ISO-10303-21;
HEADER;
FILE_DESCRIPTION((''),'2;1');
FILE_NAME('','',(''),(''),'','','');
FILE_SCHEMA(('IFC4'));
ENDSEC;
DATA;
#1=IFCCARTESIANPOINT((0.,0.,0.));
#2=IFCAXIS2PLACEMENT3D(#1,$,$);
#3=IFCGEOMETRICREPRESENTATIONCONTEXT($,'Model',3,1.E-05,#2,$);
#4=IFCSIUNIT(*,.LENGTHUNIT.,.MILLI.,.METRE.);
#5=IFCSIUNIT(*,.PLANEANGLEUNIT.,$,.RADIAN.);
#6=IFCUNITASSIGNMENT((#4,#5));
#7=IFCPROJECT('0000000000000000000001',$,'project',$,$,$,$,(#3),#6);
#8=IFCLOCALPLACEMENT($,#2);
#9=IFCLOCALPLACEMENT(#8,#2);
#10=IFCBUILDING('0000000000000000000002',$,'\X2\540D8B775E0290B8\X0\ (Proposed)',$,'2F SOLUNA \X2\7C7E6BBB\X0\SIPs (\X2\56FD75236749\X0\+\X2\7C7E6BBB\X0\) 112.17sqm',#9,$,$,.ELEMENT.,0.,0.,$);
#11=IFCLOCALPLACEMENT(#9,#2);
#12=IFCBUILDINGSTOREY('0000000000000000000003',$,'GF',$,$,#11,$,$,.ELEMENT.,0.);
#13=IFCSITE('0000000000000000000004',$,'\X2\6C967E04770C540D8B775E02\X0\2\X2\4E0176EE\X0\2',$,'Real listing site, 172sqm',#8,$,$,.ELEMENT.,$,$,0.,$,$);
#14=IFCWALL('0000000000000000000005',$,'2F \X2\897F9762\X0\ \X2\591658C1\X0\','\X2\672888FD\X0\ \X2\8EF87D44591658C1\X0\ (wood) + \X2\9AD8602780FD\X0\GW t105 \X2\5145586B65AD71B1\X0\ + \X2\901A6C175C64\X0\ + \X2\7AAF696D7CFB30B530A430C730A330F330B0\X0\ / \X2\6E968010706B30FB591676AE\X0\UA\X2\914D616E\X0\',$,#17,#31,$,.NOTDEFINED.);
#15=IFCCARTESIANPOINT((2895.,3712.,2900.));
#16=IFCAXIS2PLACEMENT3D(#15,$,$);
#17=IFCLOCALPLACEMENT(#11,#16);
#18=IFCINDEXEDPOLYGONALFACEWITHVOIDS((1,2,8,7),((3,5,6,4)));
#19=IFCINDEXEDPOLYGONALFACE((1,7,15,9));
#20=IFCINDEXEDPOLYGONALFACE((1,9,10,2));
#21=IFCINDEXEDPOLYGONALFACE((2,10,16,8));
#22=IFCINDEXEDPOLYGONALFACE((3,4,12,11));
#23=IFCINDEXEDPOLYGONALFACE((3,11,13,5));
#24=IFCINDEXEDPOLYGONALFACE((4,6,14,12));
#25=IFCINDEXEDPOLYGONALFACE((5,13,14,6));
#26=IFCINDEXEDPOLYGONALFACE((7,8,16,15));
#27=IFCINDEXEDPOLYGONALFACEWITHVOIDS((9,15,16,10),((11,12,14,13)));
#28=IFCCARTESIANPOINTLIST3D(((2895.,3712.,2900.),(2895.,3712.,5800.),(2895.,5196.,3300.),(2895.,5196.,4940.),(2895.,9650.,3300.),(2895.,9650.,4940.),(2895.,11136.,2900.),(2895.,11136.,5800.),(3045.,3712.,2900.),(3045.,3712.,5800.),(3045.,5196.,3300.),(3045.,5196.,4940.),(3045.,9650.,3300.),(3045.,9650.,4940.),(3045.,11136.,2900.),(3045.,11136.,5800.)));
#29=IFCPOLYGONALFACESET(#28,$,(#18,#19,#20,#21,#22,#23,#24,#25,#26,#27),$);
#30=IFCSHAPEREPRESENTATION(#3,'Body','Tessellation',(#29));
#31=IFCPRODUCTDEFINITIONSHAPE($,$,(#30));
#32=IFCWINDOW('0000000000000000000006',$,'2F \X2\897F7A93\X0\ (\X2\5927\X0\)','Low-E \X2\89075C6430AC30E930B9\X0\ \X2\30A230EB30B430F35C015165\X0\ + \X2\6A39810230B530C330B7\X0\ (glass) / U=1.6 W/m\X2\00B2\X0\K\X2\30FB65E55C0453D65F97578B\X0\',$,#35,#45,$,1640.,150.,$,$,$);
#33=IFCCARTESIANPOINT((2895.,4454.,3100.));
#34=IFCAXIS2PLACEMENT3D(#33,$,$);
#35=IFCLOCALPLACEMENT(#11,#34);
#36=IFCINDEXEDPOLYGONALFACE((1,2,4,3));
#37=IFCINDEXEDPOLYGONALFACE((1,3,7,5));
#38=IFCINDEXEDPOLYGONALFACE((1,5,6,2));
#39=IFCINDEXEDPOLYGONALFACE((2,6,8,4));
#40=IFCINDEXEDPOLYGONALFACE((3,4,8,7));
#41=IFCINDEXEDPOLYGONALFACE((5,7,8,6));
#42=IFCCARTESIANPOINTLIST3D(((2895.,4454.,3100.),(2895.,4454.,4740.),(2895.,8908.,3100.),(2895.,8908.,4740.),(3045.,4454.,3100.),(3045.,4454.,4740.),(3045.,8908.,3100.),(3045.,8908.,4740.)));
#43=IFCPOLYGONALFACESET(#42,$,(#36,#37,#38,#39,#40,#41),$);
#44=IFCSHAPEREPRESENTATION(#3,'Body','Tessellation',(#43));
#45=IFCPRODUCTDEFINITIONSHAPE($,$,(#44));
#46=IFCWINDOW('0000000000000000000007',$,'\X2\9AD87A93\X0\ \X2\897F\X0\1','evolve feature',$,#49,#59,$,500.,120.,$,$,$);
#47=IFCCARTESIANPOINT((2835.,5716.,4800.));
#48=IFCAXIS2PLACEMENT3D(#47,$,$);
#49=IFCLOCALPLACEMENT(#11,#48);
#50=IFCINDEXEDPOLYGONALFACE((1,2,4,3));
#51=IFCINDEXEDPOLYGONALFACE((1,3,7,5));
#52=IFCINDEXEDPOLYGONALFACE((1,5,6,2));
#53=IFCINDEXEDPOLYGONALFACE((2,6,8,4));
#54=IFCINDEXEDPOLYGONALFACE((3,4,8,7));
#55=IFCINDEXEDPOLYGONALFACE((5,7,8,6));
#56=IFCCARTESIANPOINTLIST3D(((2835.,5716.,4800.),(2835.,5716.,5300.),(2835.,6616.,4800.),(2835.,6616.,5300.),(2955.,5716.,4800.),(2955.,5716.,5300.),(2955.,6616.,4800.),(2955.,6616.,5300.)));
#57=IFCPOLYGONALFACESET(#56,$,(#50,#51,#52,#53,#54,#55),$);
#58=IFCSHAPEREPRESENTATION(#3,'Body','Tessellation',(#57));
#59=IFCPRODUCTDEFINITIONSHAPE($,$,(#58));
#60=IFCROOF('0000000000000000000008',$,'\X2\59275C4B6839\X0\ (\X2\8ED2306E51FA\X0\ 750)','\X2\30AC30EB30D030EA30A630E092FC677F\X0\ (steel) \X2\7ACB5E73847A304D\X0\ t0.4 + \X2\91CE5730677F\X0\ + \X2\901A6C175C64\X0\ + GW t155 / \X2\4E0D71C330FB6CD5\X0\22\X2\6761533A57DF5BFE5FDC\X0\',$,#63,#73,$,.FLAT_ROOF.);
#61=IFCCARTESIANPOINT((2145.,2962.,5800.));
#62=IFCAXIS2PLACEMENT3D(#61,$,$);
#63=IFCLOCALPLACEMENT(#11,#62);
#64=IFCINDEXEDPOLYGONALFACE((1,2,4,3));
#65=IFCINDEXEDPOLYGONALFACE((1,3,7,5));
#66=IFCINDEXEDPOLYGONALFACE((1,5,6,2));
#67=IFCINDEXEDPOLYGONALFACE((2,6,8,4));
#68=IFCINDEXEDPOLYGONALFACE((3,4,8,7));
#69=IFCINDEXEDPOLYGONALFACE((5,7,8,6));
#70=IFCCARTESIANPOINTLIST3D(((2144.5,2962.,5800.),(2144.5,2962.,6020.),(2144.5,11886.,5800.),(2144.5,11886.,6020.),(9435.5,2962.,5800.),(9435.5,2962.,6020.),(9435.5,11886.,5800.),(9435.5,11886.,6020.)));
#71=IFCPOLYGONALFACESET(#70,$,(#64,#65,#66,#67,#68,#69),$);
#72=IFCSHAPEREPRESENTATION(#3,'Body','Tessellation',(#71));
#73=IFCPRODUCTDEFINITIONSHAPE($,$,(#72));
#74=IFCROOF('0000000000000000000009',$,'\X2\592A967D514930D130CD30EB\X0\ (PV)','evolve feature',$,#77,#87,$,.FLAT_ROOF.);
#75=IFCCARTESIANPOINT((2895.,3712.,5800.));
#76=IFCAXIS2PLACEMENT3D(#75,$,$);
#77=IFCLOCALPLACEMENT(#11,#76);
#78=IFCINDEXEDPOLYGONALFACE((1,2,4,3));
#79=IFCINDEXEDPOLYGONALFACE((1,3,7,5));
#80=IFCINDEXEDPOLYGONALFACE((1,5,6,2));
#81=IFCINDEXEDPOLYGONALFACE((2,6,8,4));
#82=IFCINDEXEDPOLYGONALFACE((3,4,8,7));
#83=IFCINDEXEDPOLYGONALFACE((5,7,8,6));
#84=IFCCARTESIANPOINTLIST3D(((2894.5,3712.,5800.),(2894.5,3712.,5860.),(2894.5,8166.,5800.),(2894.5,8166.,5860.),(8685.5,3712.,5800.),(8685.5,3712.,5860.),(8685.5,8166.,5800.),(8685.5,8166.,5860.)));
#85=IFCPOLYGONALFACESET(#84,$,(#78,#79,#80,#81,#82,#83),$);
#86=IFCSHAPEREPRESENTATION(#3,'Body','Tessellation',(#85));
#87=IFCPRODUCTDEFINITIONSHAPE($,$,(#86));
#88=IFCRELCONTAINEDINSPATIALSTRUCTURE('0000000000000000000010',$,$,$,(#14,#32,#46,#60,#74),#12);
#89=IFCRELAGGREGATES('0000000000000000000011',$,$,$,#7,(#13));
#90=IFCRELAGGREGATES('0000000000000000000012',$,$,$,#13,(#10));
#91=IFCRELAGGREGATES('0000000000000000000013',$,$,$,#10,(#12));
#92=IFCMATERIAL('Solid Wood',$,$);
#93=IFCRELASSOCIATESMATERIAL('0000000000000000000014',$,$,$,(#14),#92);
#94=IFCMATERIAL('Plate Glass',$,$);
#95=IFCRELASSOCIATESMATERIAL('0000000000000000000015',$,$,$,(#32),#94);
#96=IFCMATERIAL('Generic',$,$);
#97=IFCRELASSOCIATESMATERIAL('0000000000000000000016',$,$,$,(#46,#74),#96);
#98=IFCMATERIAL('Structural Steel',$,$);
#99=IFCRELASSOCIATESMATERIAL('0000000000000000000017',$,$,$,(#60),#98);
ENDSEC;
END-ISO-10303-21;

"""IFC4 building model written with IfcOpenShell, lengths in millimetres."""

from ifc_helpers import new_model, si_unit, frame, frame_2d, origin, place, context, project, spatial, rectangle, extrude, material, element, fill, save


model = new_model("IFC4")

# Units and contexts
model_context = context("Model", 3, precision=1e-05, world=origin())
ifc_project = project(units=[si_unit("LENGTHUNIT", "METRE", prefix="MILLI"), si_unit("PLANEANGLEUNIT", "RADIAN")], contexts=[model_context])

# Site, building, storey
site_placement = place(None, origin())
site = spatial("IfcSite", under=ifc_project, at=site_placement, Name="沖縄県名護市2丁目2", ObjectType="Real listing site, 172sqm", CompositionType="ELEMENT", RefElevation=0.0)
building_placement = place(site_placement, origin())
building = spatial("IfcBuilding", under=site, at=building_placement, Name="名護市邸 (Proposed)", ObjectType="2F SOLUNA 籾殻SIPs (国産杉+籾殻) 112.17sqm", CompositionType="ELEMENT", ElevationOfRefHeight=0.0, ElevationOfTerrain=0.0)
storey_placement = place(building_placement, origin())
storey = spatial("IfcBuildingStorey", under=building, at=storey_placement, Name="GF", CompositionType="ELEMENT", Elevation=0.0)

# Shared definitions
ifc_material_1 = material(Name="Solid Wood")
ifc_material_2 = material(Name="Generic")

# Shared definitions
ifc_material_3 = material(Name="Plate Glass")

# Wall, openings, windows
wall_1_placement = place(storey_placement, frame((2895.0, 3712.0, 2900.0)))
wall_1 = element("IfcWall", 1, at=wall_1_placement, inside=storey, material=ifc_material_1, Name="2F 西面 外壁", Description="木製 軸組外壁 (wood) + 高性能GW t105 充填断熱 + 通気層 + 窯業系サイディング / 準耐火・外皮UA配慮", PredefinedType="NOTDEFINED", context=model_context, shape_type="SweptSolid", body=[
    extrude(rectangle(XDim=150.0, YDim=7424.0, at=frame_2d((75.0, 3712.0))), frame((2895.0, 3712.0, 2900.0)), (0.0, 0.0, 1.0), 2900.0),
])
opening_1_placement = place(storey_placement, frame((2895.0, 4454.0, 3100.0)))
opening_1 = element("IfcOpeningElement", 2, at=opening_1_placement, cuts=wall_1, PredefinedType="NOTDEFINED", context=model_context, shape_type="SweptSolid", body=[
    extrude(rectangle(XDim=150.0, YDim=4454.0, at=frame_2d((75.0, 2227.0))), frame((2895.0, 4454.0, 3100.0)), (0.0, 0.0, 1.0), 1640.0),
])
opening_2_placement = place(storey_placement, frame((2835.0, 5716.0, 4800.0)))
opening_2 = element("IfcOpeningElement", 3, at=opening_2_placement, cuts=wall_1, PredefinedType="NOTDEFINED", context=model_context, shape_type="SweptSolid", body=[
    extrude(rectangle(XDim=120.0, YDim=900.0, at=frame_2d((60.0, 450.0))), frame((2835.0, 5716.0, 4800.0)), (0.0, 0.0, 1.0), 500.0),
])
window_1_placement = place(storey_placement, frame((2895.0, 4454.0, 3100.0)))
window_1 = element("IfcWindow", 4, at=window_1_placement, inside=storey, material=ifc_material_3, Name="2F 西窓 (大)", Description="Low-E 複層ガラス アルゴン封入 + 樹脂サッシ (glass) / U=1.6 W/m²K・日射取得型", OverallHeight=1640.0, OverallWidth=150.0, context=model_context, shape_type="SweptSolid", body=[
    extrude(rectangle(XDim=150.0, YDim=4454.0, at=frame_2d((75.0, 2227.0))), frame((2895.0, 4454.0, 3100.0)), (0.0, 0.0, 1.0), 1640.0),
])
fill(opening_1, window_1)
window_2_placement = place(storey_placement, frame((2835.0, 5716.0, 4800.0)))
window_2 = element("IfcWindow", 5, at=window_2_placement, inside=storey, material=ifc_material_2, Name="高窓 西1", Description="evolve feature", OverallHeight=500.0, OverallWidth=120.0, context=model_context, shape_type="SweptSolid", body=[
    extrude(rectangle(XDim=120.0, YDim=900.0, at=frame_2d((60.0, 450.0))), frame((2835.0, 5716.0, 4800.0)), (0.0, 0.0, 1.0), 500.0),
])
fill(opening_2, window_2)

# Roofs
ifc_material_4 = material(Name="Structural Steel")
roof_1_placement = place(storey_placement, frame((2145.0, 2962.0, 5800.0)))
element("IfcRoof", 6, at=roof_1_placement, inside=storey, material=ifc_material_4, Name="大屋根 (軒の出 750)", Description="ガルバリウム鋼板 (steel) 立平葺き t0.4 + 野地板 + 通気層 + GW t155 / 不燃・法22条区域対応", PredefinedType="FLAT_ROOF", context=model_context, shape_type="SweptSolid", body=[
    extrude(rectangle(XDim=7291.0, YDim=8924.0, at=frame_2d((3645.0, 4462.0))), frame((2145.0, 2962.0, 5800.0)), (0.0, 0.0, 1.0), 220.0),
])
roof_2_placement = place(storey_placement, frame((2895.0, 3712.0, 5800.0)))
element("IfcRoof", 7, at=roof_2_placement, inside=storey, material=ifc_material_2, Name="太陽光パネル (PV)", Description="evolve feature", PredefinedType="FLAT_ROOF", context=model_context, shape_type="SweptSolid", body=[
    extrude(rectangle(XDim=5791.0, YDim=4454.0, at=frame_2d((2895.0, 2227.0))), frame((2895.0, 3712.0, 5800.0)), (0.0, 0.0, 1.0), 60.0),
])

save(model, "model.ifc")
